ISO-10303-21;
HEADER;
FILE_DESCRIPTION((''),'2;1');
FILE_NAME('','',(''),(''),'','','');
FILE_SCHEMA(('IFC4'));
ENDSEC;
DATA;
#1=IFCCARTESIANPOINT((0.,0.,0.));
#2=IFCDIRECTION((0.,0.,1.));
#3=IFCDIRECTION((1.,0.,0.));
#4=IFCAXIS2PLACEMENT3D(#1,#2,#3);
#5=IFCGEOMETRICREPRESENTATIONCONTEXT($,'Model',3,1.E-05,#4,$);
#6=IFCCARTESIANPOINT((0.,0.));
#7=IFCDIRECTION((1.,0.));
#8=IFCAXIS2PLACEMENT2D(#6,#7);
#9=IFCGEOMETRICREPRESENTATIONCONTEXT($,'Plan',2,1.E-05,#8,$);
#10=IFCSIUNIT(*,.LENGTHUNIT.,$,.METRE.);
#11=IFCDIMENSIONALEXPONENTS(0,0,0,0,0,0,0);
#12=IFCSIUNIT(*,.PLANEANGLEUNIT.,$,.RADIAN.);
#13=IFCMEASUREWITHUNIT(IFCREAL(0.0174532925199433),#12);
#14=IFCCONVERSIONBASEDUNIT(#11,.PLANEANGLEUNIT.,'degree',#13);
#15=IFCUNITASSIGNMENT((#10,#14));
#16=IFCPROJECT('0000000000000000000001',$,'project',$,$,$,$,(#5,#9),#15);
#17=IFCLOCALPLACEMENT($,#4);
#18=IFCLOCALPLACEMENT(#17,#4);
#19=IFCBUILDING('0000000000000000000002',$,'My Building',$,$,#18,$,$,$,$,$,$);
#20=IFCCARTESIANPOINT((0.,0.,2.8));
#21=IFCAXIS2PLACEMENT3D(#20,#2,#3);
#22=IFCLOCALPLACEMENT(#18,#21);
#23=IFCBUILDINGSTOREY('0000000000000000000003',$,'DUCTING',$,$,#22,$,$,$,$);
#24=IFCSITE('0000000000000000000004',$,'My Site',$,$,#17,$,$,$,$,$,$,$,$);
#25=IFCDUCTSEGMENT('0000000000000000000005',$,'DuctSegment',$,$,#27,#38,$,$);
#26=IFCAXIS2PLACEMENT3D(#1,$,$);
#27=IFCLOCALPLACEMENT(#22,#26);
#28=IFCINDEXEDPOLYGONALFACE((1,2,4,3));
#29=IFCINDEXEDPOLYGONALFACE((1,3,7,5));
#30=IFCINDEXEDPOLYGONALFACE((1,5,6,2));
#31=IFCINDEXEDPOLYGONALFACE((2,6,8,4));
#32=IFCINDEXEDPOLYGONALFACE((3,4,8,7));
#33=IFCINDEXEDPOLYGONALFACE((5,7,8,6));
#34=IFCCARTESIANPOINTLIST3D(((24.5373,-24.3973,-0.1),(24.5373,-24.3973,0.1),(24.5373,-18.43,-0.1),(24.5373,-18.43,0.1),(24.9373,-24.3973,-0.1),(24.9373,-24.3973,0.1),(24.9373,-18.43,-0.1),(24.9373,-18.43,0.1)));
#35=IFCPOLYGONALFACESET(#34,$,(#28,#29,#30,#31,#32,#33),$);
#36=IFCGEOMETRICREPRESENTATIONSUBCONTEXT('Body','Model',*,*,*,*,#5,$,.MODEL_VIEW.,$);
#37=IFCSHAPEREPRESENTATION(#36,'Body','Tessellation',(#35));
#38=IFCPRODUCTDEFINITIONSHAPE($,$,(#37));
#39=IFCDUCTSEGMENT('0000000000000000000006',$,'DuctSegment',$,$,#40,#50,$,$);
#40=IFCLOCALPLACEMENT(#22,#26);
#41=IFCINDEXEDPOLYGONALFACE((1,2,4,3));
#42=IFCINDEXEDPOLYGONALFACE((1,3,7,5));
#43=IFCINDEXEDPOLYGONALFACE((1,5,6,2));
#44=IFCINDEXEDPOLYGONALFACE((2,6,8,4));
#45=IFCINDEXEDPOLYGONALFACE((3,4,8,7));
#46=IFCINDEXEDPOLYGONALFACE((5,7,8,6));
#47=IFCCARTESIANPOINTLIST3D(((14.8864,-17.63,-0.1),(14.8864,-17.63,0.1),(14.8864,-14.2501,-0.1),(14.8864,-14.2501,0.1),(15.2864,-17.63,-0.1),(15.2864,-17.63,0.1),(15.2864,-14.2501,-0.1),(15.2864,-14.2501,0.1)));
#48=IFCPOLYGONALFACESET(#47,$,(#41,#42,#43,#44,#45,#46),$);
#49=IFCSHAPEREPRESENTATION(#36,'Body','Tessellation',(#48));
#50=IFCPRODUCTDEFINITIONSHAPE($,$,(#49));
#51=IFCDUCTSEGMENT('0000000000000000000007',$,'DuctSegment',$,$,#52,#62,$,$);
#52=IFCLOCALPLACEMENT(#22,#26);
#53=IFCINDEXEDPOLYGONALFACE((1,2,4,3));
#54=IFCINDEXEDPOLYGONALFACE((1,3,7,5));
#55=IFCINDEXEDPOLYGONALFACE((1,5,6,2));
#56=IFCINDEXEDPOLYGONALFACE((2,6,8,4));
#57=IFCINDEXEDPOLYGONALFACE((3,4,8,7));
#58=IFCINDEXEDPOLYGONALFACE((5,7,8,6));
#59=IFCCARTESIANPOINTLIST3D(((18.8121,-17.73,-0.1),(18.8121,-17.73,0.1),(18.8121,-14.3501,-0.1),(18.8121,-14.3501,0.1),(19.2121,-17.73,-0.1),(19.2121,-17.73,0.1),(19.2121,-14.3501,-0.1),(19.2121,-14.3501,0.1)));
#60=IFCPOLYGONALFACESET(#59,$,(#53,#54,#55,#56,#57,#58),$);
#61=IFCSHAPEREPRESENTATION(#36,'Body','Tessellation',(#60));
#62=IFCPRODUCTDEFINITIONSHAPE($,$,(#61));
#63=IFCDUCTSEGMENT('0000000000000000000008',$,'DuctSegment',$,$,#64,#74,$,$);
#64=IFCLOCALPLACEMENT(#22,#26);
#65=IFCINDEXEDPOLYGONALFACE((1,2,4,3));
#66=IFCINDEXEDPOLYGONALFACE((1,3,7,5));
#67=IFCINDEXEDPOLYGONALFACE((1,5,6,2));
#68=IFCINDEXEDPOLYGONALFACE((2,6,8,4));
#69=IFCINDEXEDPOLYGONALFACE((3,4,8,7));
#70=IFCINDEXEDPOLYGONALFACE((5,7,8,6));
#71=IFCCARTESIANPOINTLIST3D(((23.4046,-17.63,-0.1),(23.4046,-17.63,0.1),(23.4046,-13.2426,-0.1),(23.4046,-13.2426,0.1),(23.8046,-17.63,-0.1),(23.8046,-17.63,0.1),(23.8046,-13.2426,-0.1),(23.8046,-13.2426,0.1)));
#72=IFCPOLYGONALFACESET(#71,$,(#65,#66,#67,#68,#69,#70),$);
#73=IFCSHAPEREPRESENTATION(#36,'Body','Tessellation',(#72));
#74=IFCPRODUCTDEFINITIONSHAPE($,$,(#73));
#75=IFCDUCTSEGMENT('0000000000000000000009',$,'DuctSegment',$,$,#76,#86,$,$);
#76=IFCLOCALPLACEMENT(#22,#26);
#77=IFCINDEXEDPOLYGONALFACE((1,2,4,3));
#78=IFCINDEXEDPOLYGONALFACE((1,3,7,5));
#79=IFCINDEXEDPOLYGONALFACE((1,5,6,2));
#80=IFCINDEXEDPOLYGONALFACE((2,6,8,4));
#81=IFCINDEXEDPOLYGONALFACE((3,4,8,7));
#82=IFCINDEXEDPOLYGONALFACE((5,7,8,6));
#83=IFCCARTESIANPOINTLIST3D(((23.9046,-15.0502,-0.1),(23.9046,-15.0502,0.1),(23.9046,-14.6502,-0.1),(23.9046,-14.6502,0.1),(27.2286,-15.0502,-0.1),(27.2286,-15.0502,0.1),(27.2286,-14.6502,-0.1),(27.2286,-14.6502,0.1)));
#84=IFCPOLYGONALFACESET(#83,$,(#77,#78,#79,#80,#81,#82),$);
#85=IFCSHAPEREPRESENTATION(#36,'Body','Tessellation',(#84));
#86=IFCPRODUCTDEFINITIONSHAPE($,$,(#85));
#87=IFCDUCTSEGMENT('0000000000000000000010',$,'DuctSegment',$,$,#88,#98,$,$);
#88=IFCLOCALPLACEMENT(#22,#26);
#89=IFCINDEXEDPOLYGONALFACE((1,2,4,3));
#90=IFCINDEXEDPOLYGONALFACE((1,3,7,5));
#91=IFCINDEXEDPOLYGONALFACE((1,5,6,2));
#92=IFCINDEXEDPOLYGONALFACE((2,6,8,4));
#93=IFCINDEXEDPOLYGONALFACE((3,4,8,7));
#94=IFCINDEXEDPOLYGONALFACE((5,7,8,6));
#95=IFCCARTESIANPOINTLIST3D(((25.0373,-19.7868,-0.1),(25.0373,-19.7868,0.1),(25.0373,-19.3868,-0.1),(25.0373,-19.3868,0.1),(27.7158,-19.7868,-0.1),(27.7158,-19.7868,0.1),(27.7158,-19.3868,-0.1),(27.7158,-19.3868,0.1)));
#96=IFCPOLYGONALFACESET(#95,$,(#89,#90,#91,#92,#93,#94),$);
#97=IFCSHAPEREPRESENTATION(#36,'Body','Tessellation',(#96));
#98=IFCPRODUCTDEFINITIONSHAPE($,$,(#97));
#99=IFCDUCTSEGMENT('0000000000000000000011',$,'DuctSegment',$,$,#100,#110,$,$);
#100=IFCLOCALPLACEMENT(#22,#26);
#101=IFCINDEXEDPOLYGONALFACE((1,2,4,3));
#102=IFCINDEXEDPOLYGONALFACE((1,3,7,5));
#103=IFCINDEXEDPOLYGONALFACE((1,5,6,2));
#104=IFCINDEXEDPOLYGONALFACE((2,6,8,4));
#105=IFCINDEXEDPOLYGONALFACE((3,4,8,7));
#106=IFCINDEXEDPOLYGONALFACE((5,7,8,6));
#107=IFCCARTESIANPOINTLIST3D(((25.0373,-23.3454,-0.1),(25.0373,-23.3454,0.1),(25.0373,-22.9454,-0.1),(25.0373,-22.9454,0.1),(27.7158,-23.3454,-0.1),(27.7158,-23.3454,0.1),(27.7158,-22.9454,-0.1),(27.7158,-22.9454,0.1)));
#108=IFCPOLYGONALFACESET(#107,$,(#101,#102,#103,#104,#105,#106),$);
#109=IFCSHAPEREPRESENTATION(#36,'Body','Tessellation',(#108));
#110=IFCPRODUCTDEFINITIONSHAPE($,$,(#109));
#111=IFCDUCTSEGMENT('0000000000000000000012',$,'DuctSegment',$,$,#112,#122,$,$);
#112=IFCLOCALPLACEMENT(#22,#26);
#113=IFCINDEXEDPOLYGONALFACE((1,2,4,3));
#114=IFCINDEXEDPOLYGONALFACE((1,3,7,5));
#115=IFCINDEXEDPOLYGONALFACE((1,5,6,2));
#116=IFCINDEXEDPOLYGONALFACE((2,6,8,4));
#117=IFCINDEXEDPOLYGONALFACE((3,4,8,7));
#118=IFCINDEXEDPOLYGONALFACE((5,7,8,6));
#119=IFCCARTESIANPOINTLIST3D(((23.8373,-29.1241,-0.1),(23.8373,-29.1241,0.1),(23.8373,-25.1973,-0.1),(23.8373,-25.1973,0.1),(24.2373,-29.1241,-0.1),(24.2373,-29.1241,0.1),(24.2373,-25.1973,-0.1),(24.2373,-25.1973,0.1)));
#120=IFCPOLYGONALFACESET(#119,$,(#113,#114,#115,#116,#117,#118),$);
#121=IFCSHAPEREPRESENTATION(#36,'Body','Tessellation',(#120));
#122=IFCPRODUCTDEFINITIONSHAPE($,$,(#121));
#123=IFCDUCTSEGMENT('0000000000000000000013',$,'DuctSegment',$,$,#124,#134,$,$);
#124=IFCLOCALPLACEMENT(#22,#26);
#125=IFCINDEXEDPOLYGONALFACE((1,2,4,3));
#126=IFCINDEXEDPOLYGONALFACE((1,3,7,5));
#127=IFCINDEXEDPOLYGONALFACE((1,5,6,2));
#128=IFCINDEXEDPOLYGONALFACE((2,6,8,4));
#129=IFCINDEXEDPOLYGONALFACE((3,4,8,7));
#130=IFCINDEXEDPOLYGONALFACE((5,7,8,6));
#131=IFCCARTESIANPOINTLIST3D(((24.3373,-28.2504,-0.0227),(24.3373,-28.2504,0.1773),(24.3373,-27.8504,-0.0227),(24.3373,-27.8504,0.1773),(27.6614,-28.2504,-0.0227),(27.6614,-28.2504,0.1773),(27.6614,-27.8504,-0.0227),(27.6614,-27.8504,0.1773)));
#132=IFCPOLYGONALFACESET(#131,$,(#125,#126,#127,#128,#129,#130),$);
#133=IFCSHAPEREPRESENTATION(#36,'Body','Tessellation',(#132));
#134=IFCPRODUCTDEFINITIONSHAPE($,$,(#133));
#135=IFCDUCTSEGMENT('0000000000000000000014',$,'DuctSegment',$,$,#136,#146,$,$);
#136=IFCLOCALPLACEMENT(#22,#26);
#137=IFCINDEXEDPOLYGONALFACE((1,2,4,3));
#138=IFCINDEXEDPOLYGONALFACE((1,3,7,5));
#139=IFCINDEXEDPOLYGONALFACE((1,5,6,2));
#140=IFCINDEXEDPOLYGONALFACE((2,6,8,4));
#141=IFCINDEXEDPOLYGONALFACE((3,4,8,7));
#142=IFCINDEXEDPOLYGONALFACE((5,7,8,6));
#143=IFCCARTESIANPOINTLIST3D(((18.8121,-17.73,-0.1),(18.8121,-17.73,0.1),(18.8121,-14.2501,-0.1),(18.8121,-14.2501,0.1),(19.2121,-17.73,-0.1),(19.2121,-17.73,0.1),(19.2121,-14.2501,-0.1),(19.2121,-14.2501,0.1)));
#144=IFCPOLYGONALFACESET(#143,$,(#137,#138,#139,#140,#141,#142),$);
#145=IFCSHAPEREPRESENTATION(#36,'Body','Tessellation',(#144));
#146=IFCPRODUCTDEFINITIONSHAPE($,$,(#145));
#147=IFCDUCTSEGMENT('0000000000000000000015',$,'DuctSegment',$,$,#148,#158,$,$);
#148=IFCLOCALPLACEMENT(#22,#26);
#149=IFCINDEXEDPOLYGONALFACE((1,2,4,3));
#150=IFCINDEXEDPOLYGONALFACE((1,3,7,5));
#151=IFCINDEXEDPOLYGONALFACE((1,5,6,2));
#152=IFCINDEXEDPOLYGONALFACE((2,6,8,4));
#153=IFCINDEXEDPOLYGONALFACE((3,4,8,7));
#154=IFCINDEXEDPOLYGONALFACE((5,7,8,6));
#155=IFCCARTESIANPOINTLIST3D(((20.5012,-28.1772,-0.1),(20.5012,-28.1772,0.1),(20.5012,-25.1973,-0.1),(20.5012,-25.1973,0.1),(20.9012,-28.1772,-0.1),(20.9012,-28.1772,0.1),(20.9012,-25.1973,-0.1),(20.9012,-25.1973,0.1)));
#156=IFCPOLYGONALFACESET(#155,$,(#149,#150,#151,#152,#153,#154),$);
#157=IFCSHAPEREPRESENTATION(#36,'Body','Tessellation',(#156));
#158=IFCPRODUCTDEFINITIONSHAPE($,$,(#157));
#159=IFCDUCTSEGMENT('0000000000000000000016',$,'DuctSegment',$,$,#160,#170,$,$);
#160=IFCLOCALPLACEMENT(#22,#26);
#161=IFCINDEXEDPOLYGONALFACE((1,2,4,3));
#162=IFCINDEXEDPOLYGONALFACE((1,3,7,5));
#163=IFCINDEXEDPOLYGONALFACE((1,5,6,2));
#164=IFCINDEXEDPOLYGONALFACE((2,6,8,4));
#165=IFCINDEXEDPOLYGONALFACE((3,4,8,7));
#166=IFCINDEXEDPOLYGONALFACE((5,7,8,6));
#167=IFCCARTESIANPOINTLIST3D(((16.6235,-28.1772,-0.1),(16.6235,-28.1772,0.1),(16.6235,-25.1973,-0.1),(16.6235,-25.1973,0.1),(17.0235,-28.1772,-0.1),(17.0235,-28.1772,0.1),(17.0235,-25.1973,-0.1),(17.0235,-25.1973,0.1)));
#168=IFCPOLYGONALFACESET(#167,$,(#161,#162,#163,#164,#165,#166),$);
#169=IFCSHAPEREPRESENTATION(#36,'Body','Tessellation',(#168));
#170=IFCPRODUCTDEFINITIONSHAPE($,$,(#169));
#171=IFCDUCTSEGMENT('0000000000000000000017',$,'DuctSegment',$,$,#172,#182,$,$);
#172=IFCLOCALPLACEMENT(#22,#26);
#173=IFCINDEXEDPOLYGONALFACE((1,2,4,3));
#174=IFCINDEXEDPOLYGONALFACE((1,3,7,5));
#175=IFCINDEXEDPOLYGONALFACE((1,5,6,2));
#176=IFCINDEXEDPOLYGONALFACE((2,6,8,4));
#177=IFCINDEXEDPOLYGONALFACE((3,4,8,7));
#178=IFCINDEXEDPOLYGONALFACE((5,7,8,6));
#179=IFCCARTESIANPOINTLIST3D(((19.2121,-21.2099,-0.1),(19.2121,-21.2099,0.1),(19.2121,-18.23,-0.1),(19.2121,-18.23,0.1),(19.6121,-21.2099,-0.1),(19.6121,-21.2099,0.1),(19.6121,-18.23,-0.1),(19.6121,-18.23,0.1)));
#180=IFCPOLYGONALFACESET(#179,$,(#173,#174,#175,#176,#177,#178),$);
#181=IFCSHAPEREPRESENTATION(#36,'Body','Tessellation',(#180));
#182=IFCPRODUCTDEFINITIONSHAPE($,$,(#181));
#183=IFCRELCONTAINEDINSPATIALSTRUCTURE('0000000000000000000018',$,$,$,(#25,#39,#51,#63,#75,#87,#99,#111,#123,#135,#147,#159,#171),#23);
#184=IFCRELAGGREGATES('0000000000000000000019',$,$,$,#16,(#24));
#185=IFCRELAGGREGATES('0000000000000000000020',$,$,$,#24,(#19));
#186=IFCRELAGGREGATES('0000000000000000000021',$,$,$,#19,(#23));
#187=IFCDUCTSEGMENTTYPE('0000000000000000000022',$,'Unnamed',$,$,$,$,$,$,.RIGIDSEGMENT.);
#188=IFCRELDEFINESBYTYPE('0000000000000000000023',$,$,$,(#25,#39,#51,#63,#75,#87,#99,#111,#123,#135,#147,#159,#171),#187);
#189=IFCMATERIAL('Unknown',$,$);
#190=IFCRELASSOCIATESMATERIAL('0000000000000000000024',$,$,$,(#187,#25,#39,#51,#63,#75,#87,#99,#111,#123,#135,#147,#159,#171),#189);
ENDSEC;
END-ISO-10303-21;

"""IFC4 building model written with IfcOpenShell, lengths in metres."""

from ifc_helpers import new_model, entity, si_unit, converted_unit, frame, origin_with_axes, origin_2d_with_axis, place, context, subcontext, project, spatial, rectangle, extrude, material, material_profile, profile_set, profile_usage, type_object, element, save


model = new_model("IFC4")

# Units and contexts
model_context = context("Model", 3, precision=1e-05, world=origin_with_axes())
plan_context = context("Plan", 2, precision=1e-05, world=origin_2d_with_axis())
body_context = subcontext(model_context, "Body", "Model", "MODEL_VIEW")
ifc_project = project(units=[si_unit("LENGTHUNIT", "METRE"), converted_unit("PLANEANGLEUNIT", "degree", entity("IfcReal", 0.0174532925199433), si_unit("PLANEANGLEUNIT", "RADIAN"), dimensions=[0, 0, 0, 0, 0, 0, 0])], contexts=[model_context, plan_context])

# Site, building, storey
site_placement = place(None, origin_with_axes())
site = spatial("IfcSite", under=ifc_project, at=site_placement, Name="My Site")
building_placement = place(site_placement, origin_with_axes())
building = spatial("IfcBuilding", under=site, at=building_placement, Name="My Building")
storey_placement = place(building_placement, frame((0.0, 0.0, 2.8), z_axis=(0.0, 0.0, 1.0), x_axis=(1.0, 0.0, 0.0)))
storey = spatial("IfcBuildingStorey", under=building, at=storey_placement, Name="DUCTING")

# Duct segments
ifc_material = material(Name="Unknown")
ifc_material_profile_1 = material_profile(ifc_material, rectangle(XDim=0.4, YDim=0.2))
ifc_profile_set_1 = profile_set([ifc_material_profile_1])
ifc_profile_usage_1 = profile_usage(ifc_profile_set_1, cardinal=5)
duct_segment_type = type_object("IfcDuctSegmentType", Name="Unnamed", PredefinedType="RIGIDSEGMENT", material=ifc_profile_set_1)
duct_segment_1_placement = place(storey_placement, frame((24.7373, -18.43, 0.0), z_axis=(0.0, -1.0, 0.0), x_axis=(1.0, 0.0, 0.0)))
element("IfcDuctSegment", 1, at=duct_segment_1_placement, inside=storey, type_object=duct_segment_type, material=ifc_profile_usage_1, Name="DuctSegment", context=body_context, shape_type="SweptSolid", body=[
    extrude(rectangle(XDim=0.4, YDim=0.2), origin_with_axes(), (0.0, 0.0, 1.0), 5.9673),
])
ifc_profile_usage_2 = profile_usage(ifc_profile_set_1, cardinal=5)
duct_segment_2_placement = place(storey_placement, frame((15.0864, -17.63, 0.0), z_axis=(0.0, 1.0, 0.0), x_axis=(-1.0, 0.0, 0.0)))
element("IfcDuctSegment", 2, at=duct_segment_2_placement, inside=storey, type_object=duct_segment_type, material=ifc_profile_usage_2, Name="DuctSegment", context=body_context, shape_type="SweptSolid", body=[
    extrude(rectangle(XDim=0.4, YDim=0.2), origin_with_axes(), (0.0, 0.0, 1.0), 3.3799),
])
ifc_profile_usage_3 = profile_usage(ifc_profile_set_1, cardinal=5)
duct_segment_3_placement = place(storey_placement, frame((19.0121, -17.73, 0.0), z_axis=(0.0, 1.0, 0.0), x_axis=(-1.0, 0.0, 0.0)))
element("IfcDuctSegment", 3, at=duct_segment_3_placement, inside=storey, type_object=duct_segment_type, material=ifc_profile_usage_3, Name="DuctSegment", context=body_context, shape_type="SweptSolid", body=[
    extrude(rectangle(XDim=0.4, YDim=0.2), origin_with_axes(), (0.0, 0.0, 1.0), 3.3799),
])
ifc_profile_usage_4 = profile_usage(ifc_profile_set_1, cardinal=5)
duct_segment_4_placement = place(storey_placement, frame((23.6046, -17.63, 0.0), z_axis=(0.0, 1.0, 0.0), x_axis=(-1.0, 0.0, 0.0)))
element("IfcDuctSegment", 4, at=duct_segment_4_placement, inside=storey, type_object=duct_segment_type, material=ifc_profile_usage_4, Name="DuctSegment", context=body_context, shape_type="SweptSolid", body=[
    extrude(rectangle(XDim=0.4, YDim=0.2), origin_with_axes(), (0.0, 0.0, 1.0), 4.3874),
])
ifc_profile_usage_5 = profile_usage(ifc_profile_set_1, cardinal=5)
duct_segment_5_placement = place(storey_placement, frame((23.9046, -14.8502, 0.0), z_axis=(1.0, 0.0, 0.0), x_axis=(0.0, 1.0, 0.0)))
element("IfcDuctSegment", 5, at=duct_segment_5_placement, inside=storey, type_object=duct_segment_type, material=ifc_profile_usage_5, Name="DuctSegment", context=body_context, shape_type="SweptSolid", body=[
    extrude(rectangle(XDim=0.4, YDim=0.2), origin_with_axes(), (0.0, 0.0, 1.0), 3.3241),
])
ifc_profile_usage_6 = profile_usage(ifc_profile_set_1, cardinal=5)
duct_segment_6_placement = place(storey_placement, frame((25.0373, -19.5868, 0.0), z_axis=(1.0, 0.0, 0.0), x_axis=(0.0, 1.0, 0.0)))
element("IfcDuctSegment", 6, at=duct_segment_6_placement, inside=storey, type_object=duct_segment_type, material=ifc_profile_usage_6, Name="DuctSegment", context=body_context, shape_type="SweptSolid", body=[
    extrude(rectangle(XDim=0.4, YDim=0.2), origin_with_axes(), (0.0, 0.0, 1.0), 2.6785),
])
ifc_profile_usage_7 = profile_usage(ifc_profile_set_1, cardinal=5)
duct_segment_7_placement = place(storey_placement, frame((25.0373, -23.1454, 0.0), z_axis=(1.0, 0.0, 0.0), x_axis=(0.0, 1.0, 0.0)))
element("IfcDuctSegment", 7, at=duct_segment_7_placement, inside=storey, type_object=duct_segment_type, material=ifc_profile_usage_7, Name="DuctSegment", context=body_context, shape_type="SweptSolid", body=[
    extrude(rectangle(XDim=0.4, YDim=0.2), origin_with_axes(), (0.0, 0.0, 1.0), 2.6785),
])
ifc_profile_usage_8 = profile_usage(ifc_profile_set_1, cardinal=5)
duct_segment_8_placement = place(storey_placement, frame((24.0373, -25.1973, 0.0), z_axis=(0.0, -1.0, 0.0), x_axis=(1.0, 0.0, 0.0)))
element("IfcDuctSegment", 8, at=duct_segment_8_placement, inside=storey, type_object=duct_segment_type, material=ifc_profile_usage_8, Name="DuctSegment", context=body_context, shape_type="SweptSolid", body=[
    extrude(rectangle(XDim=0.4, YDim=0.2), origin_with_axes(), (0.0, 0.0, 1.0), 3.9268),
])
ifc_profile_usage_9 = profile_usage(ifc_profile_set_1, cardinal=5)
duct_segment_9_placement = place(storey_placement, frame((24.3373, -28.0504, 0.0773), z_axis=(1.0, 0.0, 0.0), x_axis=(0.0, 1.0, 0.0)))
element("IfcDuctSegment", 9, at=duct_segment_9_placement, inside=storey, type_object=duct_segment_type, material=ifc_profile_usage_9, Name="DuctSegment", context=body_context, shape_type="SweptSolid", body=[
    extrude(rectangle(XDim=0.4, YDim=0.2), origin_with_axes(), (0.0, 0.0, 1.0), 3.3241),
])
ifc_profile_usage_10 = profile_usage(ifc_profile_set_1, cardinal=5)
duct_segment_10_placement = place(storey_placement, frame((19.0121, -17.73, 0.0), z_axis=(0.0, 1.0, 0.0), x_axis=(-1.0, 0.0, 0.0)))
element("IfcDuctSegment", 10, at=duct_segment_10_placement, inside=storey, type_object=duct_segment_type, material=ifc_profile_usage_10, Name="DuctSegment", context=body_context, shape_type="SweptSolid", body=[
    extrude(rectangle(XDim=0.4, YDim=0.2), origin_with_axes(), (0.0, 0.0, 1.0), 3.4799),
])
ifc_profile_usage_11 = profile_usage(ifc_profile_set_1, cardinal=5)
duct_segment_11_placement = place(storey_placement, frame((20.7012, -25.1973, 0.0), z_axis=(0.0, -1.0, 0.0), x_axis=(1.0, 0.0, 0.0)))
element("IfcDuctSegment", 11, at=duct_segment_11_placement, inside=storey, type_object=duct_segment_type, material=ifc_profile_usage_11, Name="DuctSegment", context=body_context, shape_type="SweptSolid", body=[
    extrude(rectangle(XDim=0.4, YDim=0.2), origin_with_axes(), (0.0, 0.0, 1.0), 2.9799),
])
ifc_profile_usage_12 = profile_usage(ifc_profile_set_1, cardinal=5)
duct_segment_12_placement = place(storey_placement, frame((16.8235, -25.1973, 0.0), z_axis=(0.0, -1.0, 0.0), x_axis=(1.0, 0.0, 0.0)))
element("IfcDuctSegment", 12, at=duct_segment_12_placement, inside=storey, type_object=duct_segment_type, material=ifc_profile_usage_12, Name="DuctSegment", context=body_context, shape_type="SweptSolid", body=[
    extrude(rectangle(XDim=0.4, YDim=0.2), origin_with_axes(), (0.0, 0.0, 1.0), 2.9799),
])
ifc_profile_usage_13 = profile_usage(ifc_profile_set_1, cardinal=5)
duct_segment_13_placement = place(storey_placement, frame((19.4121, -18.23, 0.0), z_axis=(0.0, -1.0, 0.0), x_axis=(1.0, 0.0, 0.0)))
element("IfcDuctSegment", 13, at=duct_segment_13_placement, inside=storey, type_object=duct_segment_type, material=ifc_profile_usage_13, Name="DuctSegment", context=body_context, shape_type="SweptSolid", body=[
    extrude(rectangle(XDim=0.4, YDim=0.2), origin_with_axes(), (0.0, 0.0, 1.0), 2.9799),
])

save(model, "model.ifc")
